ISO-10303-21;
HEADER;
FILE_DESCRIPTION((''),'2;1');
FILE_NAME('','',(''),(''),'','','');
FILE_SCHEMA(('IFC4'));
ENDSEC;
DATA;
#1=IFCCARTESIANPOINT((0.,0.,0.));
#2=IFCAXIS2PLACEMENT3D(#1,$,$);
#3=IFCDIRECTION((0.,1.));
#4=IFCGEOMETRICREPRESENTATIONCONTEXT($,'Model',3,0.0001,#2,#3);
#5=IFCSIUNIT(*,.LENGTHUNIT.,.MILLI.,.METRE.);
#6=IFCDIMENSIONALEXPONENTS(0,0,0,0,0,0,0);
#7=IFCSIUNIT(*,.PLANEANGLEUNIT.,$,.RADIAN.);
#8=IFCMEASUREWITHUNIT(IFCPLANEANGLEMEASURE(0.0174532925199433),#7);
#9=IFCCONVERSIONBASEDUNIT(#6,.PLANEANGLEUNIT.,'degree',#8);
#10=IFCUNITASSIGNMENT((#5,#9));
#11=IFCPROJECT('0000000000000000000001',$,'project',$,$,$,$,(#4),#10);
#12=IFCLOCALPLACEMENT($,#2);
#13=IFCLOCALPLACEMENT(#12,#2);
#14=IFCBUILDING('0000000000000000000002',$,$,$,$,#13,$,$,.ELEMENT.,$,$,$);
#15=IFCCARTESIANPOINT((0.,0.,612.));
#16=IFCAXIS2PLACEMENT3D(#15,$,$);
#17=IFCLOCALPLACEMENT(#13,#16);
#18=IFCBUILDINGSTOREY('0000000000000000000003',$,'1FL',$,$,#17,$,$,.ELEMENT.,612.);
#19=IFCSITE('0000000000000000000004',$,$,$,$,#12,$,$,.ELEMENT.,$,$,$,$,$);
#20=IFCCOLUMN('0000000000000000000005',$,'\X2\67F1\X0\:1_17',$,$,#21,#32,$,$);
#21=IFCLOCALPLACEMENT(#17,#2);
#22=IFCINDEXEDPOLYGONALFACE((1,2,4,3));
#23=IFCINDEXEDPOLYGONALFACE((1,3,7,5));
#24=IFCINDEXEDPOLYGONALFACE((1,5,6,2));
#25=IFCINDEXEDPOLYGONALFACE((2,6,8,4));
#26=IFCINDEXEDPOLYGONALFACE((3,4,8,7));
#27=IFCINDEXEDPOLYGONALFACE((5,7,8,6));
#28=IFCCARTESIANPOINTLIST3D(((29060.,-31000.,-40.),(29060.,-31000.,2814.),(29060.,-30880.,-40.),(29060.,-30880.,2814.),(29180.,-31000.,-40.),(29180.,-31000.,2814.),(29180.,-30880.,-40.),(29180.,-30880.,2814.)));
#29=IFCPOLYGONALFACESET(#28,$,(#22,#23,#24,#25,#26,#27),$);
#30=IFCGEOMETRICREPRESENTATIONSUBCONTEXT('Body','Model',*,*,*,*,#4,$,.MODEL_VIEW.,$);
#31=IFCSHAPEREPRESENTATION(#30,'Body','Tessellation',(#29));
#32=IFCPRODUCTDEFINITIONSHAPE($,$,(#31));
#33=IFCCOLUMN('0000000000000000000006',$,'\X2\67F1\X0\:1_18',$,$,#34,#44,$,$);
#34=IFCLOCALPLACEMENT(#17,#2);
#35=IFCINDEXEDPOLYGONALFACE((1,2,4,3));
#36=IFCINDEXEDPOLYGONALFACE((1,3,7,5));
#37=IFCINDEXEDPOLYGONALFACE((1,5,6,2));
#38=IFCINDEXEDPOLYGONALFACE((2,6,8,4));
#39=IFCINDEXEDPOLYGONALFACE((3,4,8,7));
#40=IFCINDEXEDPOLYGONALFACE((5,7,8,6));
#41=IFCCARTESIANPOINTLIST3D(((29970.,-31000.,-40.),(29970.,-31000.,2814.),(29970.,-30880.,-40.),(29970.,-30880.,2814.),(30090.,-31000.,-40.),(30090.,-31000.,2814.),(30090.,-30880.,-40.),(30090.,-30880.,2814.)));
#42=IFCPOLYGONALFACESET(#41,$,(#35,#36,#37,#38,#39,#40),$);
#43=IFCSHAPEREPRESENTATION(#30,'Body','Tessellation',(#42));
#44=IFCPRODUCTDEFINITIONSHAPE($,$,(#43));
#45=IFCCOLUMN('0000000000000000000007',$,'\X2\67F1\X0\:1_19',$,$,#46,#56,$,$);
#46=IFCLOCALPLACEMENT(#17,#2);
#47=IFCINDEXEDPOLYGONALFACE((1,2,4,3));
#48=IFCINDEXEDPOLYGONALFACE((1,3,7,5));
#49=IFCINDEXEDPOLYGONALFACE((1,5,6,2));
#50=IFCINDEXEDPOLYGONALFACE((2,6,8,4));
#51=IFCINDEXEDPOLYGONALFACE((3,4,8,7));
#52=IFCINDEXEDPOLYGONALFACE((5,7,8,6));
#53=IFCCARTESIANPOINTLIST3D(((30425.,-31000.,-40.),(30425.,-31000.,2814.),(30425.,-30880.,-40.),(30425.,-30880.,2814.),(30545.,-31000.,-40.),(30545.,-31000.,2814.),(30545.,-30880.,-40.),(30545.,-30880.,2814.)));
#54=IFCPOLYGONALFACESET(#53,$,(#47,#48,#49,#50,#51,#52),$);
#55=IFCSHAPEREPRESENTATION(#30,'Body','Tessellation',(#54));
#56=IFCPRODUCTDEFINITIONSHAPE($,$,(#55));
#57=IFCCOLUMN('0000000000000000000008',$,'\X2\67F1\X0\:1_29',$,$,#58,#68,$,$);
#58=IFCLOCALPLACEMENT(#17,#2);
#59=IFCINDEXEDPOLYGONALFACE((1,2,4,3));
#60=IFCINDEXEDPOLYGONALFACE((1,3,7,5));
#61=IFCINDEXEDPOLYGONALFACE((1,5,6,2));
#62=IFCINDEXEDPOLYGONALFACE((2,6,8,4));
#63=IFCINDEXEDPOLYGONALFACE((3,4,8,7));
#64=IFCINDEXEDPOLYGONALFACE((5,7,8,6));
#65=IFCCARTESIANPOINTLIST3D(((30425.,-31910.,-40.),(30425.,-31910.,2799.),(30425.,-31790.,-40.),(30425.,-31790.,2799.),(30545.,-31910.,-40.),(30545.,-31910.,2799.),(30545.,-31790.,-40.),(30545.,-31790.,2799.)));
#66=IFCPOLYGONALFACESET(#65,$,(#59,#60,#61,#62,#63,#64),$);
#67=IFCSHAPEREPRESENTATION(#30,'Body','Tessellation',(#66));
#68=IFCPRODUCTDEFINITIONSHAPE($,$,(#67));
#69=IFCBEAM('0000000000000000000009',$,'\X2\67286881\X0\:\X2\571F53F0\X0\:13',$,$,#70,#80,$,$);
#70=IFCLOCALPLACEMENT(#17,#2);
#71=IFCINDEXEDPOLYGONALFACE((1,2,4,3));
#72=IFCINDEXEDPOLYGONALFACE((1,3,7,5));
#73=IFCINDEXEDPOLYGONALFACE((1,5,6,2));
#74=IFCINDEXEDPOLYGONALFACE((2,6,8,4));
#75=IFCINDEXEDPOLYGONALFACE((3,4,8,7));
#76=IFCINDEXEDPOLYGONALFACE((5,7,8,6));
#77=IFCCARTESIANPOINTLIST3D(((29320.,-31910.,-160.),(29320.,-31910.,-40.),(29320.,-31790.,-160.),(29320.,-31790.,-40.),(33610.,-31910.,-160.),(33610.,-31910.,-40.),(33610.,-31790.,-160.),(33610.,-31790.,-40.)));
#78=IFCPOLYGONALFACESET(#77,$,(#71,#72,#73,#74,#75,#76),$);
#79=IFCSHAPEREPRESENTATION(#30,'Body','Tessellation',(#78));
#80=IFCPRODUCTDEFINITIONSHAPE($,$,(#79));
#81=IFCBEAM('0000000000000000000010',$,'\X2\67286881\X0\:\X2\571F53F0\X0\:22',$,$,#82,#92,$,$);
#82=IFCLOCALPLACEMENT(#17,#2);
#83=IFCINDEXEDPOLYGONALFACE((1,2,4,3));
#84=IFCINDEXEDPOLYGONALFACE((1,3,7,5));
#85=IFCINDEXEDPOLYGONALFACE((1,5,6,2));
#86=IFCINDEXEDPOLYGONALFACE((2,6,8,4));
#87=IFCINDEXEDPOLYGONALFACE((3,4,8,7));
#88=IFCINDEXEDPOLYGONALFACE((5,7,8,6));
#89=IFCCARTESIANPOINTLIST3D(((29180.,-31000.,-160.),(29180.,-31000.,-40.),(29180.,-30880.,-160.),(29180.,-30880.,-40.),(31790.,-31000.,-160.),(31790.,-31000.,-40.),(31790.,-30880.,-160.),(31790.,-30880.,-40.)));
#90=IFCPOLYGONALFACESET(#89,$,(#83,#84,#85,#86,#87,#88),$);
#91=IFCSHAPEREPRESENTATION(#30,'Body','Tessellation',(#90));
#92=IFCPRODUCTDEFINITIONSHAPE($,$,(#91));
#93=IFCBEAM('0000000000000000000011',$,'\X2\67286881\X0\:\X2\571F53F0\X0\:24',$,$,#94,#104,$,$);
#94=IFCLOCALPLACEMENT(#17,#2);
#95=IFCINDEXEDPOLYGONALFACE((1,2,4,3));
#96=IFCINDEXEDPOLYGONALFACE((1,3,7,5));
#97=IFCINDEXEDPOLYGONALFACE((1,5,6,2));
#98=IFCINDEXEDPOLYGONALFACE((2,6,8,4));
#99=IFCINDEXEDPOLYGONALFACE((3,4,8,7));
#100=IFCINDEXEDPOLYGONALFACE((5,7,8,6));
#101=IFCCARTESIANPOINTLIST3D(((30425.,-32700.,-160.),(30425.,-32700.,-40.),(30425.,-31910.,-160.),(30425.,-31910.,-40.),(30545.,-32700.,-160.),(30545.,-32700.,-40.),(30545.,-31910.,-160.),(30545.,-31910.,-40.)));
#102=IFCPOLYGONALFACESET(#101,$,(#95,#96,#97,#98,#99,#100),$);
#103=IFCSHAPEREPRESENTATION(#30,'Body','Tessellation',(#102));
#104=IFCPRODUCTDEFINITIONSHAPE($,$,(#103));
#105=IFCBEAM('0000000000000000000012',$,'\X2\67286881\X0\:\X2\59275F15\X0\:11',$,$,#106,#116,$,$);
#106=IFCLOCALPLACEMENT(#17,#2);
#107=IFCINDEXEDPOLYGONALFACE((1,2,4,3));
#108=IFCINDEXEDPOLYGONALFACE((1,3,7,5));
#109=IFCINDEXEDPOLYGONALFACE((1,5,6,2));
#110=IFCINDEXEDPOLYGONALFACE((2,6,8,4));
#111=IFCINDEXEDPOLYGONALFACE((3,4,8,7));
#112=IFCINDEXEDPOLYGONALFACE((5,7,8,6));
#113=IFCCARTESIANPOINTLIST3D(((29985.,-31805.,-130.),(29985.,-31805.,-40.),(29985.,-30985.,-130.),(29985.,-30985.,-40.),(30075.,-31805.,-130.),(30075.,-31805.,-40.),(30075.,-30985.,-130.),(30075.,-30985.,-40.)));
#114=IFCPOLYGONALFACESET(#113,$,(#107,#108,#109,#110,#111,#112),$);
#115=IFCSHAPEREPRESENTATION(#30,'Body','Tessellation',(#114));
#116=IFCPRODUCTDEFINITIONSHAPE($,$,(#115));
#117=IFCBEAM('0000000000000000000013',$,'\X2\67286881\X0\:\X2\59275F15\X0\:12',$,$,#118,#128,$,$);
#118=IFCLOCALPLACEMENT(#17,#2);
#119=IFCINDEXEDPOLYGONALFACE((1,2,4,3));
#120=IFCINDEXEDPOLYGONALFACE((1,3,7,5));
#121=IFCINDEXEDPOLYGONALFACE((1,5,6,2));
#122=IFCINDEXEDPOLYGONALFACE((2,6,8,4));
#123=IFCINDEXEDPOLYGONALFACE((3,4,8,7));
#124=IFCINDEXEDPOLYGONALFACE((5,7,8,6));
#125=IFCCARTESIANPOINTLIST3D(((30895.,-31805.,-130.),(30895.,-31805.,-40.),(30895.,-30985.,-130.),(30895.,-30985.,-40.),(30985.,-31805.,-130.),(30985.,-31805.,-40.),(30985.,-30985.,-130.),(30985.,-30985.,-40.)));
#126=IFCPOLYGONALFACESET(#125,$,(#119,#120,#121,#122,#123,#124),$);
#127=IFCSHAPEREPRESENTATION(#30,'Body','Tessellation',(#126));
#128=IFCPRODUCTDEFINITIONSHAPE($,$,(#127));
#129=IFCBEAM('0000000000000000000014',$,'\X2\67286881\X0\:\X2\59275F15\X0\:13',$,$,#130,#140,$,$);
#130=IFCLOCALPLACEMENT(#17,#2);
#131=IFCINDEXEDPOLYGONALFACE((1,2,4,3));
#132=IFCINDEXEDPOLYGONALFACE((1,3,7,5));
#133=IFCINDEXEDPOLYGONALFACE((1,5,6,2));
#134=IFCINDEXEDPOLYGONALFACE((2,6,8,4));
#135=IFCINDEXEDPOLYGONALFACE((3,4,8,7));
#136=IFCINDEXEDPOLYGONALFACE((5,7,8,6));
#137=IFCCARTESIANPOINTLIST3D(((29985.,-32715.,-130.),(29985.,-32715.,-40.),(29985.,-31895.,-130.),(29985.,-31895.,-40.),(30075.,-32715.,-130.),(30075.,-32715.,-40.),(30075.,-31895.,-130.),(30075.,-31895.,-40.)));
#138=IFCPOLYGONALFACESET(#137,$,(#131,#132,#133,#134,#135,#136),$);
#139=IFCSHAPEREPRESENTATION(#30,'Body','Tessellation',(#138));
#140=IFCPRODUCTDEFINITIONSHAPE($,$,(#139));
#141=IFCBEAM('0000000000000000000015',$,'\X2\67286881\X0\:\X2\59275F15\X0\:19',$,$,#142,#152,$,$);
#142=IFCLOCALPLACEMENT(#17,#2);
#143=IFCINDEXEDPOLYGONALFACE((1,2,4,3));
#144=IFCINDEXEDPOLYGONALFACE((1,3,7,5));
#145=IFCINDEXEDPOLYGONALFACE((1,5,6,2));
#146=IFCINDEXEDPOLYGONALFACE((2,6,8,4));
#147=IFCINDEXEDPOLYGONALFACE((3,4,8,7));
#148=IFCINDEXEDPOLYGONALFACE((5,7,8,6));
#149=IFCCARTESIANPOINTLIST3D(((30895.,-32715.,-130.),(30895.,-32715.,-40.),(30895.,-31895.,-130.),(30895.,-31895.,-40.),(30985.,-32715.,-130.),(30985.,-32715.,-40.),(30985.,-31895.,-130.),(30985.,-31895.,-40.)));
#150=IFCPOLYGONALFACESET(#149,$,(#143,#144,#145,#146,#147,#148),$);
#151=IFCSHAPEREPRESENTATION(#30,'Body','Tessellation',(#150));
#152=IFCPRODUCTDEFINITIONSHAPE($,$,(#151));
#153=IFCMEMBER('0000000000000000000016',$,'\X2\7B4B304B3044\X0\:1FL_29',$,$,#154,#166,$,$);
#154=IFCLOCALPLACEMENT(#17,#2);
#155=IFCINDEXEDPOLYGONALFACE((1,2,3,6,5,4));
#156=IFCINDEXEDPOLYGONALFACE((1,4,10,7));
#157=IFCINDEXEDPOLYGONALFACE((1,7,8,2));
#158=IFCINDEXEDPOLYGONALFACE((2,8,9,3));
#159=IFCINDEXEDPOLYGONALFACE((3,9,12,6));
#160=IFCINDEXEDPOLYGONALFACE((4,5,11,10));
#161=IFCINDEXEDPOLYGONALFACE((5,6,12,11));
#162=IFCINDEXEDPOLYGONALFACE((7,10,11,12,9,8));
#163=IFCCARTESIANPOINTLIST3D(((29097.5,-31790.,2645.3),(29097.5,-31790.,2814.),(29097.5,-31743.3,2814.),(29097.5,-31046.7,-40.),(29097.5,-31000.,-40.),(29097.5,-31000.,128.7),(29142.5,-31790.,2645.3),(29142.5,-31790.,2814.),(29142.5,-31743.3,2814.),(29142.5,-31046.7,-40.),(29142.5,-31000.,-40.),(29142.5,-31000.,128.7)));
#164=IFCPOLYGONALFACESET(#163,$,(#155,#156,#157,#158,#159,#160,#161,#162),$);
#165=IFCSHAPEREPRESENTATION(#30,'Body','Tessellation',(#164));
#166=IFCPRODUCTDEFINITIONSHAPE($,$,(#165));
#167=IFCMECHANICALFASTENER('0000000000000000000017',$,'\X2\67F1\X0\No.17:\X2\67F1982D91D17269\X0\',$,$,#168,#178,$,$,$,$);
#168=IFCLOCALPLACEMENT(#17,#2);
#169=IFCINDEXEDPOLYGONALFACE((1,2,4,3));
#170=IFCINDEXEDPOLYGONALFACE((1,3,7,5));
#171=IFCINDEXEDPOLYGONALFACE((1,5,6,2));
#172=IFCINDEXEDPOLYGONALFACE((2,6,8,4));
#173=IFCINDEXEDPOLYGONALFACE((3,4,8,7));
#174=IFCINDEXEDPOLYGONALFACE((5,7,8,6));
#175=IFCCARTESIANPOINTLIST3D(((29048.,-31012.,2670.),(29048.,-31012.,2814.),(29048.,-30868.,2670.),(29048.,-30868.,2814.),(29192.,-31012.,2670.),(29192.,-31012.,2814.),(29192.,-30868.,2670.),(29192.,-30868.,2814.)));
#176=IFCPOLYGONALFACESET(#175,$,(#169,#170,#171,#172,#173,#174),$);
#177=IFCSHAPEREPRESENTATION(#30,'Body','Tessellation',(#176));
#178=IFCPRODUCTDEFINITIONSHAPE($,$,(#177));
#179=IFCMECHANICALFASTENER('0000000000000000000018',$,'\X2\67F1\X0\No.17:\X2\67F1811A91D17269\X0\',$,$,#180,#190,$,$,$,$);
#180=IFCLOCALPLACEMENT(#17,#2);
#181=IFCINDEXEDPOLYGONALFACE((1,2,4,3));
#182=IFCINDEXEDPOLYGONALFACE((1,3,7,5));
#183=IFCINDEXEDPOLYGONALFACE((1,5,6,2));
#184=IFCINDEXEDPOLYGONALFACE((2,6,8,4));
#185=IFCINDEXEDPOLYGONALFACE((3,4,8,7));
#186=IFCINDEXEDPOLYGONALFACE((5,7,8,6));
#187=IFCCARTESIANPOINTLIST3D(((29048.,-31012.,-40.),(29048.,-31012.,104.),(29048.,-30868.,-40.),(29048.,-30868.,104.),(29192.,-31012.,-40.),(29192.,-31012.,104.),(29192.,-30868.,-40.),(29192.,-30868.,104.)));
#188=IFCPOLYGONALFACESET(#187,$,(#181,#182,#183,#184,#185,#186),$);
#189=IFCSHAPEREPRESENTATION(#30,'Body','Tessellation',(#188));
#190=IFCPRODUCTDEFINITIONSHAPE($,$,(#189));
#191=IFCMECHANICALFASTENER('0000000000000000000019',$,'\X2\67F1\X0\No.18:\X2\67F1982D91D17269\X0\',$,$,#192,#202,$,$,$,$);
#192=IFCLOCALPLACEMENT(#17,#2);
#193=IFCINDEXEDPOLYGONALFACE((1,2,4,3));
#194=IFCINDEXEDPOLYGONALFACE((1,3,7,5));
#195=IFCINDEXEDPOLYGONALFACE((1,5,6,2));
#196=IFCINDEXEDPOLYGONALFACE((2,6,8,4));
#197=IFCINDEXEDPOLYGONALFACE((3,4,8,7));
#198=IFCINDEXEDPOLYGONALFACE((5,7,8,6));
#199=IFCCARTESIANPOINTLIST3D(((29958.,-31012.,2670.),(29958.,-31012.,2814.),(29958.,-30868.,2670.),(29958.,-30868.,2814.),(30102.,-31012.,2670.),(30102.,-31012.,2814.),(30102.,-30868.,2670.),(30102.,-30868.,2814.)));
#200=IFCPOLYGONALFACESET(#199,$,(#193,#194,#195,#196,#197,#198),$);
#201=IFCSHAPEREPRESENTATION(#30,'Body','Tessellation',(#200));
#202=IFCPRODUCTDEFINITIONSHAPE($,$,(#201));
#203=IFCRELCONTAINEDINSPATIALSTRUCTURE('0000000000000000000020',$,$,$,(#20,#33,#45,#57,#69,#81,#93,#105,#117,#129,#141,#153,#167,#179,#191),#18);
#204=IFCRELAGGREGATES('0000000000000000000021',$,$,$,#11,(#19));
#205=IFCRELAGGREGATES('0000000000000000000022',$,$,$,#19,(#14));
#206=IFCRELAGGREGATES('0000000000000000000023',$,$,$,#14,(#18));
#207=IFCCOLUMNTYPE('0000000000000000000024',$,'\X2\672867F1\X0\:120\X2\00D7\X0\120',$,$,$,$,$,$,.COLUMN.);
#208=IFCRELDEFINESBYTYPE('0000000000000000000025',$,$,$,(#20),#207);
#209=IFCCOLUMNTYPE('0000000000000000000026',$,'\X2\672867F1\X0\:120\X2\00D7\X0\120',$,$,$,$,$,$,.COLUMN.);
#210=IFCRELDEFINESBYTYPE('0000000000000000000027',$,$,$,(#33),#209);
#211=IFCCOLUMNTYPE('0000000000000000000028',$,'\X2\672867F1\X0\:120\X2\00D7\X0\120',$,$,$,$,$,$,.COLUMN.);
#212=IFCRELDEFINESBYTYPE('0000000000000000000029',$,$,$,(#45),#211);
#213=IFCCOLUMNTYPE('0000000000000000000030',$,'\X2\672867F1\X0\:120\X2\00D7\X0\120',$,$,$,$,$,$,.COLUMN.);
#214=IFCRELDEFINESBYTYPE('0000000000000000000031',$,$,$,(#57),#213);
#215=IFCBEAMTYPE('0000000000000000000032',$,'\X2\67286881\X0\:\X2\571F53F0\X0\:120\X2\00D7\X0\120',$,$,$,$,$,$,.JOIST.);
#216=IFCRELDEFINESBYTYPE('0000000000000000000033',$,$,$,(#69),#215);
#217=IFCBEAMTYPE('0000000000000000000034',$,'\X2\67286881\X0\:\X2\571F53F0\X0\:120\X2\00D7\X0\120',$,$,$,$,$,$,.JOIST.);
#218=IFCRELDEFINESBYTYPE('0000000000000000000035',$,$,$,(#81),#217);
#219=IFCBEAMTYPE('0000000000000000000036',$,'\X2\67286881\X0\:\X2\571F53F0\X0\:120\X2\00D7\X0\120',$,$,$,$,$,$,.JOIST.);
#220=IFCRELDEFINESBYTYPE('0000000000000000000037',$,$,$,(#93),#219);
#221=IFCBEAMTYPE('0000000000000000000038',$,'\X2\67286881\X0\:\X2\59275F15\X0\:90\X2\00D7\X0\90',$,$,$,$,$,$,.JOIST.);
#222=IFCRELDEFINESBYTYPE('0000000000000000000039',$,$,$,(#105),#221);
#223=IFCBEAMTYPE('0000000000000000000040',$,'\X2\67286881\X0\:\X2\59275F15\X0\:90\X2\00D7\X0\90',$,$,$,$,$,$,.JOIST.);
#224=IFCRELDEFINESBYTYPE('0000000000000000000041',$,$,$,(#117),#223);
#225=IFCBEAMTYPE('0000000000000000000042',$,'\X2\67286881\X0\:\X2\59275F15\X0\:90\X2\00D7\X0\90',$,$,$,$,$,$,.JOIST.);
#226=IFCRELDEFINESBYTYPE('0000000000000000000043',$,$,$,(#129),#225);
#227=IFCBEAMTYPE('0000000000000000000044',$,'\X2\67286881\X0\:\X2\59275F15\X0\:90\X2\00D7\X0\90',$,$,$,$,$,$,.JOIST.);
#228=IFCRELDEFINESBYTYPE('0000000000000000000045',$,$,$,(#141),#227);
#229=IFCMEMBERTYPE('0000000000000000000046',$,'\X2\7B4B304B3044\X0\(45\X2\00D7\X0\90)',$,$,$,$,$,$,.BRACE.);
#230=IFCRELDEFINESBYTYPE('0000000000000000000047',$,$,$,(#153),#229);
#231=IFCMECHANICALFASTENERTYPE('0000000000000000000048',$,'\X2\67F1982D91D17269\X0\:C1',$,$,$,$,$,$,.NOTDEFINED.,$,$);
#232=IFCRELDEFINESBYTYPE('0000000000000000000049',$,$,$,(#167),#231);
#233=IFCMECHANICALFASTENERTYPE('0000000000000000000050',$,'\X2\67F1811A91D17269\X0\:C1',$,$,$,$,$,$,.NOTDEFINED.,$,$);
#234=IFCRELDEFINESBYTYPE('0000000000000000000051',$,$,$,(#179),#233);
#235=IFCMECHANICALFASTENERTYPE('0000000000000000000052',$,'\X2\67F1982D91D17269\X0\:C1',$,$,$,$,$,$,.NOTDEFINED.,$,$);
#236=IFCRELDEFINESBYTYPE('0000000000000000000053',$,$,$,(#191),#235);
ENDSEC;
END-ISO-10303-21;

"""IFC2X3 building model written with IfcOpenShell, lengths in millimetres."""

from ifc_helpers import new_model, entity, si_unit, converted_unit, direction, frame, origin, origin_with_axes, origin_2d, place, context, subcontext, project, spatial, polyline, rectangle, outline, extrude, type_object, element, save


model = new_model("IFC2X3")

# Units and contexts
model_context = context("Model", 3, precision=0.0001, world=origin(), true_north=direction((0.0, 1.0)))
body_context = subcontext(model_context, "Body", "Model", "MODEL_VIEW")
ifc_project = project(units=[si_unit("LENGTHUNIT", "METRE", prefix="MILLI"), converted_unit("PLANEANGLEUNIT", "degree", entity("IfcPlaneAngleMeasure", 0.0174532925199433), si_unit("PLANEANGLEUNIT", "RADIAN"), dimensions=[0, 0, 0, 0, 0, 0, 0])], contexts=[model_context])

# Site, building, storey
site_placement = place(None, origin())
site = spatial("IfcSite", under=ifc_project, at=site_placement, CompositionType="ELEMENT")
building_placement = place(site_placement, origin())
building = spatial("IfcBuilding", under=site, at=building_placement, CompositionType="ELEMENT")
storey_placement = place(building_placement, frame((0.0, 0.0, 612.0)))
storey = spatial("IfcBuildingStorey", under=building, at=storey_placement, Name="1FL", CompositionType="ELEMENT", Elevation=612.0)

# Columns
column_type_1 = type_object("IfcColumnType", Name="木柱:120×120", PredefinedType="COLUMN")
column_1_placement = place(storey_placement, frame((29120.0, -30940.0, -40.0)))
element("IfcColumn", 1, at=column_1_placement, inside=storey, type_object=column_type_1, Name="柱:1_17", context=body_context, shape_type="SweptSolid", body=[
    extrude(rectangle(XDim=120.0, YDim=120.0, at=origin_2d()), origin_with_axes(), (0.0, 0.0, 1.0), 2854.0),
])
column_type_2 = type_object("IfcColumnType", Name="木柱:120×120", PredefinedType="COLUMN")
column_2_placement = place(storey_placement, frame((30030.0, -30940.0, -40.0)))
element("IfcColumn", 2, at=column_2_placement, inside=storey, type_object=column_type_2, Name="柱:1_18", context=body_context, shape_type="SweptSolid", body=[
    extrude(rectangle(XDim=120.0, YDim=120.0, at=origin_2d()), origin_with_axes(), (0.0, 0.0, 1.0), 2854.0),
])
column_type_3 = type_object("IfcColumnType", Name="木柱:120×120", PredefinedType="COLUMN")
column_3_placement = place(storey_placement, frame((30485.0, -30940.0, -40.0)))
element("IfcColumn", 3, at=column_3_placement, inside=storey, type_object=column_type_3, Name="柱:1_19", context=body_context, shape_type="SweptSolid", body=[
    extrude(rectangle(XDim=120.0, YDim=120.0, at=origin_2d()), origin_with_axes(), (0.0, 0.0, 1.0), 2854.0),
])
column_type_4 = type_object("IfcColumnType", Name="木柱:120×120", PredefinedType="COLUMN")
column_4_placement = place(storey_placement, frame((30485.0, -31850.0, -40.0)))
element("IfcColumn", 4, at=column_4_placement, inside=storey, type_object=column_type_4, Name="柱:1_29", context=body_context, shape_type="SweptSolid", body=[
    extrude(rectangle(XDim=120.0, YDim=120.0, at=origin_2d()), origin_with_axes(), (0.0, 0.0, 1.0), 2839.0),
])

# Beams
beam_type_1 = type_object("IfcBeamType", Name="木梁:土台:120×120", PredefinedType="JOIST")
beam_1_placement = place(storey_placement, frame((29320.0, -31850.0, -100.0), z_axis=(1.0, 0.0, 0.0), x_axis=(0.0, 1.0, 0.0)))
element("IfcBeam", 5, at=beam_1_placement, inside=storey, type_object=beam_type_1, Name="木梁:土台:13", context=body_context, shape_type="SweptSolid", body=[
    extrude(rectangle(XDim=120.0, YDim=120.0, at=origin_2d()), origin_with_axes(), (0.0, 0.0, 1.0), 4290.0),
])
beam_type_2 = type_object("IfcBeamType", Name="木梁:土台:120×120", PredefinedType="JOIST")
beam_2_placement = place(storey_placement, frame((29180.0, -30940.0, -100.0), z_axis=(1.0, 0.0, 0.0), x_axis=(0.0, 1.0, 0.0)))
element("IfcBeam", 6, at=beam_2_placement, inside=storey, type_object=beam_type_2, Name="木梁:土台:22", context=body_context, shape_type="SweptSolid", body=[
    extrude(rectangle(XDim=120.0, YDim=120.0, at=origin_2d()), origin_with_axes(), (0.0, 0.0, 1.0), 2610.0),
])
beam_type_3 = type_object("IfcBeamType", Name="木梁:土台:120×120", PredefinedType="JOIST")
beam_3_placement = place(storey_placement, frame((30485.0, -31910.0, -100.0), z_axis=(0.0, -1.0, 0.0), x_axis=(1.0, 0.0, 0.0)))
element("IfcBeam", 7, at=beam_3_placement, inside=storey, type_object=beam_type_3, Name="木梁:土台:24", context=body_context, shape_type="SweptSolid", body=[
    extrude(rectangle(XDim=120.0, YDim=120.0, at=origin_2d()), origin_with_axes(), (0.0, 0.0, 1.0), 790.0),
])
beam_type_4 = type_object("IfcBeamType", Name="木梁:大引:90×90", PredefinedType="JOIST")
beam_4_placement = place(storey_placement, frame((30030.0, -30985.0, -85.0), z_axis=(0.0, -1.0, 0.0), x_axis=(1.0, 0.0, 0.0)))
element("IfcBeam", 8, at=beam_4_placement, inside=storey, type_object=beam_type_4, Name="木梁:大引:11", context=body_context, shape_type="SweptSolid", body=[
    extrude(rectangle(XDim=90.0, YDim=90.0, at=origin_2d()), origin_with_axes(), (0.0, 0.0, 1.0), 820.0),
])
beam_type_5 = type_object("IfcBeamType", Name="木梁:大引:90×90", PredefinedType="JOIST")
beam_5_placement = place(storey_placement, frame((30940.0, -30985.0, -85.0), z_axis=(0.0, -1.0, 0.0), x_axis=(1.0, 0.0, 0.0)))
element("IfcBeam", 9, at=beam_5_placement, inside=storey, type_object=beam_type_5, Name="木梁:大引:12", context=body_context, shape_type="SweptSolid", body=[
    extrude(rectangle(XDim=90.0, YDim=90.0, at=origin_2d()), origin_with_axes(), (0.0, 0.0, 1.0), 820.0),
])
beam_type_6 = type_object("IfcBeamType", Name="木梁:大引:90×90", PredefinedType="JOIST")
beam_6_placement = place(storey_placement, frame((30030.0, -31895.0, -85.0), z_axis=(0.0, -1.0, 0.0), x_axis=(1.0, 0.0, 0.0)))
element("IfcBeam", 10, at=beam_6_placement, inside=storey, type_object=beam_type_6, Name="木梁:大引:13", context=body_context, shape_type="SweptSolid", body=[
    extrude(rectangle(XDim=90.0, YDim=90.0, at=origin_2d()), origin_with_axes(), (0.0, 0.0, 1.0), 820.0),
])
beam_type_7 = type_object("IfcBeamType", Name="木梁:大引:90×90", PredefinedType="JOIST")
beam_7_placement = place(storey_placement, frame((30940.0, -31895.0, -85.0), z_axis=(0.0, -1.0, 0.0), x_axis=(1.0, 0.0, 0.0)))
element("IfcBeam", 11, at=beam_7_placement, inside=storey, type_object=beam_type_7, Name="木梁:大引:19", context=body_context, shape_type="SweptSolid", body=[
    extrude(rectangle(XDim=90.0, YDim=90.0, at=origin_2d()), origin_with_axes(), (0.0, 0.0, 1.0), 820.0),
])

# Member
member_type = type_object("IfcMemberType", Name="筋かい(45×90)", PredefinedType="BRACE")
member_placement = place(storey_placement, frame((29120.0, -31000.0, -40.0), z_axis=(0.0, -0.266773, 0.963759), x_axis=(0.0, 0.963759, 0.266773)))
element("IfcMember", 12, at=member_placement, inside=storey, type_object=member_type, Name="筋かい:1FL_29", context=body_context, shape_type="SweptSolid", body=[
    extrude(outline(polyline([(0.0, 0.0), (12.5, -45.0), (2798.8, -45.0), (2961.3, 0.0), (2948.9, 45.0), (162.6, 45.0), (0.0, 0.0)])), frame((0.0, -22.5, 0.0), z_axis=(0.0, 1.0, 0.0), x_axis=(0.0, 0.0, 1.0)), (0.0, 0.0, 1.0), 45.0),
])

# Mechanical fasteners
mechanical_fastener_type_1 = type_object("IfcMechanicalFastenerType", Name="柱頭金物:C1")
mechanical_fastener_1_placement = place(storey_placement, frame((29120.0, -30940.0, 2670.0)))
element("IfcMechanicalFastener", 13, at=mechanical_fastener_1_placement, inside=storey, type_object=mechanical_fastener_type_1, Name="柱No.17:柱頭金物", context=body_context, shape_type="SweptSolid", body=[
    extrude(rectangle(XDim=144.0, YDim=144.0, at=origin_2d()), origin_with_axes(), (0.0, 0.0, 1.0), 144.0),
])
mechanical_fastener_type_2 = type_object("IfcMechanicalFastenerType", Name="柱脚金物:C1")
mechanical_fastener_2_placement = place(storey_placement, frame((29120.0, -30940.0, -40.0)))
element("IfcMechanicalFastener", 14, at=mechanical_fastener_2_placement, inside=storey, type_object=mechanical_fastener_type_2, Name="柱No.17:柱脚金物", context=body_context, shape_type="SweptSolid", body=[
    extrude(rectangle(XDim=144.0, YDim=144.0, at=origin_2d()), origin_with_axes(), (0.0, 0.0, 1.0), 144.0),
])
mechanical_fastener_type_3 = type_object("IfcMechanicalFastenerType", Name="柱頭金物:C1")
mechanical_fastener_3_placement = place(storey_placement, frame((30030.0, -30940.0, 2670.0)))
element("IfcMechanicalFastener", 15, at=mechanical_fastener_3_placement, inside=storey, type_object=mechanical_fastener_type_3, Name="柱No.18:柱頭金物", context=body_context, shape_type="SweptSolid", body=[
    extrude(rectangle(XDim=144.0, YDim=144.0, at=origin_2d()), origin_with_axes(), (0.0, 0.0, 1.0), 144.0),
])

save(model, "model.ifc")
